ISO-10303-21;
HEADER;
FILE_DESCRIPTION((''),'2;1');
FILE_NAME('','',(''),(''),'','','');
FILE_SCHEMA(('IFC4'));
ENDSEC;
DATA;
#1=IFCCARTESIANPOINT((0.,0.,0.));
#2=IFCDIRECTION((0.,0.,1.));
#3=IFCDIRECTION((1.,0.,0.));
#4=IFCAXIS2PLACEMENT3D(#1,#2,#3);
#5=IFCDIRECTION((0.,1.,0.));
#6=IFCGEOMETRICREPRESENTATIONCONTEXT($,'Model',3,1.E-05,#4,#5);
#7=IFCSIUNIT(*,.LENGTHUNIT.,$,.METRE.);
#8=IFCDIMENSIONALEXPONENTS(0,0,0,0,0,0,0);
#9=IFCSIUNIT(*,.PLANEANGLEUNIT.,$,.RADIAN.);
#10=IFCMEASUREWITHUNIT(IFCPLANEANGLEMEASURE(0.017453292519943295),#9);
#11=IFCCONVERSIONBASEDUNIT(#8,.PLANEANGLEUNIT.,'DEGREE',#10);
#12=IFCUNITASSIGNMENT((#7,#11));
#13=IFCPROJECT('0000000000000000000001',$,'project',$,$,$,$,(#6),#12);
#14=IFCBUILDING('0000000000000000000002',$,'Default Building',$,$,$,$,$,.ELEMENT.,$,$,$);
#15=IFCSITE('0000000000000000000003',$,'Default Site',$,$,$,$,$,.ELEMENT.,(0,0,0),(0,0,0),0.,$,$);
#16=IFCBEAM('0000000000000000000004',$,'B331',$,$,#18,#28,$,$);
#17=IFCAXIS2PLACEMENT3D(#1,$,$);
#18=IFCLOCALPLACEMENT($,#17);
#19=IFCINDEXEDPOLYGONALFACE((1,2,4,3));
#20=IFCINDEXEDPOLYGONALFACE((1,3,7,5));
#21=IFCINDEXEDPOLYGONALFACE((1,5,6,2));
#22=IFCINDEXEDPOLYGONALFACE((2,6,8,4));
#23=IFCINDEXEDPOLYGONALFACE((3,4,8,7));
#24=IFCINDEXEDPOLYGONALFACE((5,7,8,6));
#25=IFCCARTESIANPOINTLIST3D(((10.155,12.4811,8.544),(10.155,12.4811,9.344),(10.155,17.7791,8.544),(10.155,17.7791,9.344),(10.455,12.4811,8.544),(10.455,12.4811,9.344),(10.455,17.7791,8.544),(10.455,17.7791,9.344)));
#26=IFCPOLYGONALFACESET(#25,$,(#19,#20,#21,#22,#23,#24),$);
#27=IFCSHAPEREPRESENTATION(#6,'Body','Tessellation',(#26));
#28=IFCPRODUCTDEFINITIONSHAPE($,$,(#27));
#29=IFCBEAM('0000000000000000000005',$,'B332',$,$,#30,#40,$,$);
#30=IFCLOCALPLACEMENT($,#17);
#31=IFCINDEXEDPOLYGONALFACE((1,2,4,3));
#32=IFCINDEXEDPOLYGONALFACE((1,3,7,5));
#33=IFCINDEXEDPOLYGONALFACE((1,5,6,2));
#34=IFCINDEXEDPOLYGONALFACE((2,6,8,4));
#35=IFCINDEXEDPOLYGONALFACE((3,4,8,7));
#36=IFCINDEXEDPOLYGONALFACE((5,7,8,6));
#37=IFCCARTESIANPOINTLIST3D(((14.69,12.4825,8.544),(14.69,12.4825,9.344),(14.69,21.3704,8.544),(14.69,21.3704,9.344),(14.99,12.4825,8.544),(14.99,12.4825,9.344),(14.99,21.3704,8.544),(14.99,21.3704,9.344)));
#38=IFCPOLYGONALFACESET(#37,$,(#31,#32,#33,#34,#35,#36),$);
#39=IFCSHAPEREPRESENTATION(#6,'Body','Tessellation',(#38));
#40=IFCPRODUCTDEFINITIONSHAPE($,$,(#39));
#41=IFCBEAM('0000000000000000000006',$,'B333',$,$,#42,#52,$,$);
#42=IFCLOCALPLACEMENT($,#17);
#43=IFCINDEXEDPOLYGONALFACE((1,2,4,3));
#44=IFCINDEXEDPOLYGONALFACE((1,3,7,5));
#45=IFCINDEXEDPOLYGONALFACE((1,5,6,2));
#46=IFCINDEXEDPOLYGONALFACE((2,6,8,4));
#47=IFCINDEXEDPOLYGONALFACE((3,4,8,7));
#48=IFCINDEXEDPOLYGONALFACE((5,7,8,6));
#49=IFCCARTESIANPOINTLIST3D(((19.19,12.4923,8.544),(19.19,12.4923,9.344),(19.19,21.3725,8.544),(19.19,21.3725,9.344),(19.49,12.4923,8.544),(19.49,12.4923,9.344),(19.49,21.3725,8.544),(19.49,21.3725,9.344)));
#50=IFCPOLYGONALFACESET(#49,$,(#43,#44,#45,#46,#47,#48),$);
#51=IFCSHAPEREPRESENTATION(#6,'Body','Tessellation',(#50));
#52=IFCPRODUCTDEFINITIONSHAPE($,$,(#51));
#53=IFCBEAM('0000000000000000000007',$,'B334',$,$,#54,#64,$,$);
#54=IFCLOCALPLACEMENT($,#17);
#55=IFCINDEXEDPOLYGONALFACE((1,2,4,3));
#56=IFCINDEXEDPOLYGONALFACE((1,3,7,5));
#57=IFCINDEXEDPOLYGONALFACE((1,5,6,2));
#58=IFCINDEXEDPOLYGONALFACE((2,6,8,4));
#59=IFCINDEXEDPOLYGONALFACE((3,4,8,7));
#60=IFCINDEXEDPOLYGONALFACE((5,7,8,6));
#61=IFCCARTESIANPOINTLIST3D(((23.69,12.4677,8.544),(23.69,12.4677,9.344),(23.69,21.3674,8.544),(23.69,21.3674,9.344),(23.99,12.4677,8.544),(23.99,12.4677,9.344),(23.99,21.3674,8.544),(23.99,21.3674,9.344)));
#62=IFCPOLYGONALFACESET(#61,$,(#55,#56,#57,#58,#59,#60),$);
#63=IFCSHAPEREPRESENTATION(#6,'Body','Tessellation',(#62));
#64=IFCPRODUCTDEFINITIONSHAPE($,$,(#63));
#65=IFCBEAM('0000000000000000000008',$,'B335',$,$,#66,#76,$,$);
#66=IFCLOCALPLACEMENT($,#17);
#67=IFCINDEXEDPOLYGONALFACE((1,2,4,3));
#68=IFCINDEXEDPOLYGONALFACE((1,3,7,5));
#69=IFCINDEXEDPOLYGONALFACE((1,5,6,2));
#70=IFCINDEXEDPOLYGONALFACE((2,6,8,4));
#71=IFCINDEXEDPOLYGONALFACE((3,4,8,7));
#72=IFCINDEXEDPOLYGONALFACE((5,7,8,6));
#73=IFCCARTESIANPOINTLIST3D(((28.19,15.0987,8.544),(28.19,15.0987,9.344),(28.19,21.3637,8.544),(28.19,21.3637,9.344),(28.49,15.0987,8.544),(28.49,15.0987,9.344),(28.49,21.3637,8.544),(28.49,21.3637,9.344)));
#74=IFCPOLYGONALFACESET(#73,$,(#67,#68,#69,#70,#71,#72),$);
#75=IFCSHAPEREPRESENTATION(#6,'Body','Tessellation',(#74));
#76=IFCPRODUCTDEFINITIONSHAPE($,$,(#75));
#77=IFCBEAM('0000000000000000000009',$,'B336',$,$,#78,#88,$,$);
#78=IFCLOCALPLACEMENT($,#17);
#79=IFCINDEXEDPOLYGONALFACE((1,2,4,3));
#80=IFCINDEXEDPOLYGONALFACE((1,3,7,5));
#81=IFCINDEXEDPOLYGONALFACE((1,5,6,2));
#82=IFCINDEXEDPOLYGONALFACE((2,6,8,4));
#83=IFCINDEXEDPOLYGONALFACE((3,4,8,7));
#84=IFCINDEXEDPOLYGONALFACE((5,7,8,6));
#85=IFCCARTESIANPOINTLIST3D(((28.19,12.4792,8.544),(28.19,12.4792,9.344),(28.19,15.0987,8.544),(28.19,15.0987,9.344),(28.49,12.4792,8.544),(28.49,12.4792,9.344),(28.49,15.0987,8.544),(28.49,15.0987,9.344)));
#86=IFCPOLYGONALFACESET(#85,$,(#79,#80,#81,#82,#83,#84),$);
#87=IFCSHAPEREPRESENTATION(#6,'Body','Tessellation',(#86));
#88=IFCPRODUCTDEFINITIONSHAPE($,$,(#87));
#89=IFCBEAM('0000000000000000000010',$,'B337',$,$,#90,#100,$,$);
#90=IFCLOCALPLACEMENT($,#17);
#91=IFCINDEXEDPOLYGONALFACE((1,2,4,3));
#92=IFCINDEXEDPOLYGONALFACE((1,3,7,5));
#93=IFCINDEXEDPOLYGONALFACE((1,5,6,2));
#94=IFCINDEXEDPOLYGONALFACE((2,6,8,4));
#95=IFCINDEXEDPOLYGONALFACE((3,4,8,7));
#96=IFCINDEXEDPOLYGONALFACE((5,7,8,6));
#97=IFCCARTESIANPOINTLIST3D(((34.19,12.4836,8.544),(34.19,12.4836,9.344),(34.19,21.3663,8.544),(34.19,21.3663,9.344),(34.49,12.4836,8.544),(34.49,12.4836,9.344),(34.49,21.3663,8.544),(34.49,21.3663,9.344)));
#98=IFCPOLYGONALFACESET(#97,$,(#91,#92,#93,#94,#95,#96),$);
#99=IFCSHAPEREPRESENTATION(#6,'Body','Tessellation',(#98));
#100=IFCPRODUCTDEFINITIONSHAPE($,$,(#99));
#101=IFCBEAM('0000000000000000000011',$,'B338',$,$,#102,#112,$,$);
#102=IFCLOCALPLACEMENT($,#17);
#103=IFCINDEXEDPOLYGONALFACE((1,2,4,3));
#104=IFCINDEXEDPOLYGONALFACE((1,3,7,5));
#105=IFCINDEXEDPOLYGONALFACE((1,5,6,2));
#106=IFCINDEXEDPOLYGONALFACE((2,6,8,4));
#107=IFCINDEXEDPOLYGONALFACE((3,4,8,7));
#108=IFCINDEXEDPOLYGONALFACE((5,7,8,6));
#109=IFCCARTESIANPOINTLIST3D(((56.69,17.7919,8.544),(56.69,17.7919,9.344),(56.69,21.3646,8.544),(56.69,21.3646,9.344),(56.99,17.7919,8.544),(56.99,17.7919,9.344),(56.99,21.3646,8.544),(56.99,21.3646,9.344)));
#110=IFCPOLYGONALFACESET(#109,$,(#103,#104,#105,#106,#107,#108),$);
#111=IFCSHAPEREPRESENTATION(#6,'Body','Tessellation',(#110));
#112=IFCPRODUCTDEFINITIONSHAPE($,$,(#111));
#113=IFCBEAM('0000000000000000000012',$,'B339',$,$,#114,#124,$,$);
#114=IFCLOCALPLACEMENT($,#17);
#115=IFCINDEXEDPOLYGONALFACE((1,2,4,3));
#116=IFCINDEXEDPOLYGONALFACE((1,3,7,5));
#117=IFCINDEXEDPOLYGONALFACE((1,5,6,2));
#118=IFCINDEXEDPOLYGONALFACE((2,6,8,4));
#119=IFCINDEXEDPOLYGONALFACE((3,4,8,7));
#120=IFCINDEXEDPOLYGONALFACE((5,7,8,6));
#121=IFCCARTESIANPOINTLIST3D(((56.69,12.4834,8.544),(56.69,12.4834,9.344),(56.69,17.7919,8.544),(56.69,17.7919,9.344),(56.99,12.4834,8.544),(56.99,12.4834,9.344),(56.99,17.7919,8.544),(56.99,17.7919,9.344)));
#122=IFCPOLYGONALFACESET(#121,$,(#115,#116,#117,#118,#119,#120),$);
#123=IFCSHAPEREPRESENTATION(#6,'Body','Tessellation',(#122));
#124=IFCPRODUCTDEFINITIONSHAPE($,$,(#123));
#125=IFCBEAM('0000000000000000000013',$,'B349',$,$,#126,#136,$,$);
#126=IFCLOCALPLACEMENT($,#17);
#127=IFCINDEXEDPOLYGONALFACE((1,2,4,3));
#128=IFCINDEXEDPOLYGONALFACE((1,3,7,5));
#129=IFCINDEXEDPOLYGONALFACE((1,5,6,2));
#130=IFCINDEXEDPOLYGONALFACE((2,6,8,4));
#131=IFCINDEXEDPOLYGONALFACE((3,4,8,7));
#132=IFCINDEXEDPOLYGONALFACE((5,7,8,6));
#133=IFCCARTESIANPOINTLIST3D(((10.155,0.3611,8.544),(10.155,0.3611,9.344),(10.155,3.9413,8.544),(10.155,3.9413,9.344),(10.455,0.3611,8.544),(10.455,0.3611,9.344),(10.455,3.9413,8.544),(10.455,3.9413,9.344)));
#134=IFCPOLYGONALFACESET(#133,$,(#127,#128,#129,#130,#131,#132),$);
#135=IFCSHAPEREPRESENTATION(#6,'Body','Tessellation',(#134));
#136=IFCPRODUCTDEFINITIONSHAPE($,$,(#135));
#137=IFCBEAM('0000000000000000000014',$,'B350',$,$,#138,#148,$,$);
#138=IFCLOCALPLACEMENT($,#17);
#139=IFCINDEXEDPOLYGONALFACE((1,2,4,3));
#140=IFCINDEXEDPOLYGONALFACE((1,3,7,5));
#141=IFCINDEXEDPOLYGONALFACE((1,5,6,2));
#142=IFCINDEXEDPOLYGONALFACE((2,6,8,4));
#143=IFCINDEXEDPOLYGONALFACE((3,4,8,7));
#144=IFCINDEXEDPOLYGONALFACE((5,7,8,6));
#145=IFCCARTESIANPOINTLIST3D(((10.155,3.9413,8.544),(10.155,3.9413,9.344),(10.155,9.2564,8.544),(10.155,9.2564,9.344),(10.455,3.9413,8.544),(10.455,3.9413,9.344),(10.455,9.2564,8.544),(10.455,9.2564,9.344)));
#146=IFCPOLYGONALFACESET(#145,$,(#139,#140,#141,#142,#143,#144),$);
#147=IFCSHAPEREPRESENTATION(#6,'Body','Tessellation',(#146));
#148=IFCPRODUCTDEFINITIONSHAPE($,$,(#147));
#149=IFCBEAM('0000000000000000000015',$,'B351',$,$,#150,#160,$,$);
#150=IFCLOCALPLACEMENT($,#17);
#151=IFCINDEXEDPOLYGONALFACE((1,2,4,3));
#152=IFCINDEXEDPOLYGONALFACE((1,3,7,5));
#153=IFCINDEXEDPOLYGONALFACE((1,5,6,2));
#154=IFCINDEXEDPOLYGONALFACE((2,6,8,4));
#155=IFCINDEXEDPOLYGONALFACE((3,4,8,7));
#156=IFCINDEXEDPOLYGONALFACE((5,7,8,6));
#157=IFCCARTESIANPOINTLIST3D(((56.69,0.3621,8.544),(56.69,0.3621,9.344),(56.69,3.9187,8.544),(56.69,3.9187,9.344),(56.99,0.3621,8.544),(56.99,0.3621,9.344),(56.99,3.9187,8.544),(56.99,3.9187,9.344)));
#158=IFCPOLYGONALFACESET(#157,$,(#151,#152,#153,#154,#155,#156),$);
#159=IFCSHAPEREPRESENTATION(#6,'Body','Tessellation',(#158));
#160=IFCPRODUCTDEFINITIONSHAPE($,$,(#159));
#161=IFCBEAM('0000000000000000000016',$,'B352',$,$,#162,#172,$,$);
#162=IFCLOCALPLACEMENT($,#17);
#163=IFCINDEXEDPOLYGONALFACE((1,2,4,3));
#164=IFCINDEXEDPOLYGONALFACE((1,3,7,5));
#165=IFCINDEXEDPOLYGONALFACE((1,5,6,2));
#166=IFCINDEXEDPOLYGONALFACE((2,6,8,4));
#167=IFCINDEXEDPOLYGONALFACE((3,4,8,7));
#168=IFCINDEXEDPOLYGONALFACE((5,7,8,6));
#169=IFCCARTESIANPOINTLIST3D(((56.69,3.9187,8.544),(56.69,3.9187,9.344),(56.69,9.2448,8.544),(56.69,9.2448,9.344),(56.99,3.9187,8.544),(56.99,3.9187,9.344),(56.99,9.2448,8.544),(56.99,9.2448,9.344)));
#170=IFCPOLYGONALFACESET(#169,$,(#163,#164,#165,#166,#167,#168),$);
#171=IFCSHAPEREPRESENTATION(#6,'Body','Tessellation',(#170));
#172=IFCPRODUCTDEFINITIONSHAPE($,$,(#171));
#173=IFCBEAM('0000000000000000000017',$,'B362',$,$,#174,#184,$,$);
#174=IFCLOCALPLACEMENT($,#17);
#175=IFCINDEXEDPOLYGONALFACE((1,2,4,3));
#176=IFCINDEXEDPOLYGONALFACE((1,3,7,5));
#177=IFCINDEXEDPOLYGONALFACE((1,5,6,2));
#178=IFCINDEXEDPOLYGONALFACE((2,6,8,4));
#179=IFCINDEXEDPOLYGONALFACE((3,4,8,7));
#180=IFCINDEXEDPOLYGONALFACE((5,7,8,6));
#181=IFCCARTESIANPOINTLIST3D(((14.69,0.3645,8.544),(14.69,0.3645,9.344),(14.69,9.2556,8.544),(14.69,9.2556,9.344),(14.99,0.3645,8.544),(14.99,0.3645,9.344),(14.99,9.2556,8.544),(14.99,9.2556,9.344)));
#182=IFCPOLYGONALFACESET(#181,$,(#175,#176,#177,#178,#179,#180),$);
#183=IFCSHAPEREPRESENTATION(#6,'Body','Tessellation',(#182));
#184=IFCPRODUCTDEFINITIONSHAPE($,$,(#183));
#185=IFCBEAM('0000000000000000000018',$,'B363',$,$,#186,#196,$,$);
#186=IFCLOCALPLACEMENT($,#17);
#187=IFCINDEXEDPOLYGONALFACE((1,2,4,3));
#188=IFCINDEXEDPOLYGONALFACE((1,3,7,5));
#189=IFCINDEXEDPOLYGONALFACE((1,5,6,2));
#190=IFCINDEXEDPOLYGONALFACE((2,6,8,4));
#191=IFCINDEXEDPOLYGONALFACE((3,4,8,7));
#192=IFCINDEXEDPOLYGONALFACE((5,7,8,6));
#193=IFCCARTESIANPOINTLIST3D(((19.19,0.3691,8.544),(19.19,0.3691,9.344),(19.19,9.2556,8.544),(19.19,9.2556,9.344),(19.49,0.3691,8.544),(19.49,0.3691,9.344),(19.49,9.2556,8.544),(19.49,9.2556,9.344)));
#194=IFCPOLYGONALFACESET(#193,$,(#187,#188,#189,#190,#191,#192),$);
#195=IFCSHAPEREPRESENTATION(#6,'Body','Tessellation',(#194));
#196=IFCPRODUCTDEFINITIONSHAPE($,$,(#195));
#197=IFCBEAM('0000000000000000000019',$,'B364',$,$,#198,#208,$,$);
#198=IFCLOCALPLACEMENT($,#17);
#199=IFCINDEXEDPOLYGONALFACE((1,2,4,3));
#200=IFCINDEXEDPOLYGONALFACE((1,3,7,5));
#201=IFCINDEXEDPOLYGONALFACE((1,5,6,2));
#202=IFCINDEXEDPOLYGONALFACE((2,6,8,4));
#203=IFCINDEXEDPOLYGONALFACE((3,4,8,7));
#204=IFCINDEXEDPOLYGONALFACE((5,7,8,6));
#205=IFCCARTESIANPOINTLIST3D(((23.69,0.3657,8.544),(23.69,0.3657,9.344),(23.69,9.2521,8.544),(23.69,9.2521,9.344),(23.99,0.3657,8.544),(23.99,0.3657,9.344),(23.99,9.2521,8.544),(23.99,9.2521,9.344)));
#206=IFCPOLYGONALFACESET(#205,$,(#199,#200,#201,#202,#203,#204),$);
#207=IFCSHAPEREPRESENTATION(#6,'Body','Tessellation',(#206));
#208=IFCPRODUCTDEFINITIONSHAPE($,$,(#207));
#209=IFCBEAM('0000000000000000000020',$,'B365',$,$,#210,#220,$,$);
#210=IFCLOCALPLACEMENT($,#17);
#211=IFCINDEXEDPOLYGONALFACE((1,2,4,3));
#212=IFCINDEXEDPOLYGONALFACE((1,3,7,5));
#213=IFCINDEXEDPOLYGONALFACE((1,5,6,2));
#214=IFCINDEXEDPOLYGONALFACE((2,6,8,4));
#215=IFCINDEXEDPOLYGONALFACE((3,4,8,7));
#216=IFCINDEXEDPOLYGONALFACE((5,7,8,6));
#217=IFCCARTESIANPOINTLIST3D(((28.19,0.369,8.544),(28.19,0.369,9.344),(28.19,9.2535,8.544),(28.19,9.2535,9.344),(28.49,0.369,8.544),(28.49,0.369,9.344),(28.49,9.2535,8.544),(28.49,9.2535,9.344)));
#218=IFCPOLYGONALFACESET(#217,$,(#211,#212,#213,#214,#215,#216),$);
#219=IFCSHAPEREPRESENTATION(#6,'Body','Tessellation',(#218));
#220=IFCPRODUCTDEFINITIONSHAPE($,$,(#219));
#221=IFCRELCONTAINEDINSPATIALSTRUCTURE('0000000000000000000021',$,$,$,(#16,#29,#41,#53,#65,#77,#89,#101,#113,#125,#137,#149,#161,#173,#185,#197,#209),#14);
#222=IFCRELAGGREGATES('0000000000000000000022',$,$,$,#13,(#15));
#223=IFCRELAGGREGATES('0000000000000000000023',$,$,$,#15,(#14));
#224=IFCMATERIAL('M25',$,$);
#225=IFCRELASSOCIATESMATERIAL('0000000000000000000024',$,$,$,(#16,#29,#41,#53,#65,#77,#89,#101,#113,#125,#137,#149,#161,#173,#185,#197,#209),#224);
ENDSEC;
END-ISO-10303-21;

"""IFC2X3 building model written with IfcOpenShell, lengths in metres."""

from ifc_helpers import new_model, entity, si_unit, converted_unit, direction, frame, frame_2d, origin_with_axes, place, context, project, spatial, rectangle, extrude, material, element, save


model = new_model("IFC2X3")

# Units and contexts
model_context = context("Model", 3, precision=1e-05, world=origin_with_axes(), true_north=direction((0.0, 1.0, 0.0)))
ifc_project = project(units=[si_unit("LENGTHUNIT", "METRE"), converted_unit("PLANEANGLEUNIT", "DEGREE", entity("IfcPlaneAngleMeasure", 0.017453292519943295), si_unit("PLANEANGLEUNIT", "RADIAN"), dimensions=[0, 0, 0, 0, 0, 0, 0])], contexts=[model_context])

# Site, building
site = spatial("IfcSite", under=ifc_project, Name="Default Site", CompositionType="ELEMENT", RefLatitude=(0, 0, 0), RefLongitude=(0, 0, 0), RefElevation=0.0)
building = spatial("IfcBuilding", under=site, Name="Default Building", CompositionType="ELEMENT")

# Beams
ifc_material = material(Name="M25")
placement = place(None, origin_with_axes())
element("IfcBeam", 1, at=placement, inside=building, material=ifc_material, Name="B331", context=model_context, shape_type="SweptSolid", body=[
    extrude(rectangle(XDim=0.3, YDim=0.8, at=frame_2d((0.0, 0.0), x_axis=(0.0, 1.0, 0.0))), frame((10.305, 17.7791, 8.944), z_axis=(0.0, -1.0, 0.0), x_axis=(0.0, 0.0, -1.0)), (0.0, 0.0, 1.0), 5.298),
])
element("IfcBeam", 2, at=placement, inside=building, material=ifc_material, Name="B332", context=model_context, shape_type="SweptSolid", body=[
    extrude(rectangle(XDim=0.3, YDim=0.8, at=frame_2d((0.0, 0.0), x_axis=(0.0, 1.0, 0.0))), frame((14.84, 21.3704, 8.944), z_axis=(0.0, -1.0, 0.0), x_axis=(0.0, 0.0, -1.0)), (0.0, 0.0, 1.0), 8.8879),
])
element("IfcBeam", 3, at=placement, inside=building, material=ifc_material, Name="B333", context=model_context, shape_type="SweptSolid", body=[
    extrude(rectangle(XDim=0.3, YDim=0.8, at=frame_2d((0.0, 0.0), x_axis=(0.0, 1.0, 0.0))), frame((19.34, 21.3725, 8.944), z_axis=(0.0, -1.0, 0.0), x_axis=(0.0, 0.0, -1.0)), (0.0, 0.0, 1.0), 8.8802),
])
element("IfcBeam", 4, at=placement, inside=building, material=ifc_material, Name="B334", context=model_context, shape_type="SweptSolid", body=[
    extrude(rectangle(XDim=0.3, YDim=0.8, at=frame_2d((0.0, 0.0), x_axis=(0.0, 1.0, 0.0))), frame((23.84, 21.3674, 8.944), z_axis=(0.0, -1.0, 0.0), x_axis=(0.0, 0.0, -1.0)), (0.0, 0.0, 1.0), 8.8997),
])
element("IfcBeam", 5, at=placement, inside=building, material=ifc_material, Name="B335", context=model_context, shape_type="SweptSolid", body=[
    extrude(rectangle(XDim=0.3, YDim=0.8, at=frame_2d((0.0, 0.0), x_axis=(0.0, 1.0, 0.0))), frame((28.34, 21.3637, 8.944), z_axis=(0.0, -1.0, 0.0), x_axis=(0.0, 0.0, -1.0)), (0.0, 0.0, 1.0), 6.265),
])
element("IfcBeam", 6, at=placement, inside=building, material=ifc_material, Name="B336", context=model_context, shape_type="SweptSolid", body=[
    extrude(rectangle(XDim=0.3, YDim=0.8, at=frame_2d((0.0, 0.0), x_axis=(0.0, 1.0, 0.0))), frame((28.34, 15.0987, 8.944), z_axis=(0.0, -1.0, 0.0), x_axis=(0.0, 0.0, -1.0)), (0.0, 0.0, 1.0), 2.6195),
])
element("IfcBeam", 7, at=placement, inside=building, material=ifc_material, Name="B337", context=model_context, shape_type="SweptSolid", body=[
    extrude(rectangle(XDim=0.3, YDim=0.8, at=frame_2d((0.0, 0.0), x_axis=(0.0, 1.0, 0.0))), frame((34.34, 12.4836, 8.944), z_axis=(0.0, 1.0, 0.0), x_axis=(0.0, 0.0, -1.0)), (0.0, 0.0, 1.0), 8.8827),
])
element("IfcBeam", 8, at=placement, inside=building, material=ifc_material, Name="B338", context=model_context, shape_type="SweptSolid", body=[
    extrude(rectangle(XDim=0.3, YDim=0.8, at=frame_2d((0.0, 0.0), x_axis=(0.0, 1.0, 0.0))), frame((56.84, 17.7919, 8.944), z_axis=(0.0, 1.0, 0.0), x_axis=(0.0, 0.0, -1.0)), (0.0, 0.0, 1.0), 3.5727),
])
element("IfcBeam", 9, at=placement, inside=building, material=ifc_material, Name="B339", context=model_context, shape_type="SweptSolid", body=[
    extrude(rectangle(XDim=0.3, YDim=0.8, at=frame_2d((0.0, 0.0), x_axis=(0.0, 1.0, 0.0))), frame((56.84, 12.4834, 8.944), z_axis=(0.0, 1.0, 0.0), x_axis=(0.0, 0.0, -1.0)), (0.0, 0.0, 1.0), 5.3085),
])
element("IfcBeam", 10, at=placement, inside=building, material=ifc_material, Name="B349", context=model_context, shape_type="SweptSolid", body=[
    extrude(rectangle(XDim=0.3, YDim=0.8, at=frame_2d((0.0, 0.0), x_axis=(0.0, 1.0, 0.0))), frame((10.305, 3.9413, 8.944), z_axis=(0.0, -1.0, 0.0), x_axis=(0.0, 0.0, -1.0)), (0.0, 0.0, 1.0), 3.5802),
])
element("IfcBeam", 11, at=placement, inside=building, material=ifc_material, Name="B350", context=model_context, shape_type="SweptSolid", body=[
    extrude(rectangle(XDim=0.3, YDim=0.8, at=frame_2d((0.0, 0.0), x_axis=(0.0, 1.0, 0.0))), frame((10.305, 3.9413, 8.944), z_axis=(0.0, 1.0, 0.0), x_axis=(0.0, 0.0, -1.0)), (0.0, 0.0, 1.0), 5.3151),
])
element("IfcBeam", 12, at=placement, inside=building, material=ifc_material, Name="B351", context=model_context, shape_type="SweptSolid", body=[
    extrude(rectangle(XDim=0.3, YDim=0.8, at=frame_2d((0.0, 0.0), x_axis=(0.0, 1.0, 0.0))), frame((56.84, 0.3621, 8.944), z_axis=(0.0, 1.0, 0.0), x_axis=(0.0, 0.0, -1.0)), (0.0, 0.0, 1.0), 3.5566),
])
element("IfcBeam", 13, at=placement, inside=building, material=ifc_material, Name="B352", context=model_context, shape_type="SweptSolid", body=[
    extrude(rectangle(XDim=0.3, YDim=0.8, at=frame_2d((0.0, 0.0), x_axis=(0.0, 1.0, 0.0))), frame((56.84, 3.9187, 8.944), z_axis=(0.0, 1.0, 0.0), x_axis=(0.0, 0.0, -1.0)), (0.0, 0.0, 1.0), 5.3261),
])
element("IfcBeam", 14, at=placement, inside=building, material=ifc_material, Name="B362", context=model_context, shape_type="SweptSolid", body=[
    extrude(rectangle(XDim=0.3, YDim=0.8, at=frame_2d((0.0, 0.0), x_axis=(0.0, 1.0, 0.0))), frame((14.84, 0.3645, 8.944), z_axis=(0.0, 1.0, 0.0), x_axis=(0.0, 0.0, -1.0)), (0.0, 0.0, 1.0), 8.891),
])
element("IfcBeam", 15, at=placement, inside=building, material=ifc_material, Name="B363", context=model_context, shape_type="SweptSolid", body=[
    extrude(rectangle(XDim=0.3, YDim=0.8, at=frame_2d((0.0, 0.0), x_axis=(0.0, 1.0, 0.0))), frame((19.34, 0.3691, 8.944), z_axis=(0.0, 1.0, 0.0), x_axis=(0.0, 0.0, -1.0)), (0.0, 0.0, 1.0), 8.8865),
])
element("IfcBeam", 16, at=placement, inside=building, material=ifc_material, Name="B364", context=model_context, shape_type="SweptSolid", body=[
    extrude(rectangle(XDim=0.3, YDim=0.8, at=frame_2d((0.0, 0.0), x_axis=(0.0, 1.0, 0.0))), frame((23.84, 0.3657, 8.944), z_axis=(0.0, 1.0, 0.0), x_axis=(0.0, 0.0, -1.0)), (0.0, 0.0, 1.0), 8.8864),
])
element("IfcBeam", 17, at=placement, inside=building, material=ifc_material, Name="B365", context=model_context, shape_type="SweptSolid", body=[
    extrude(rectangle(XDim=0.3, YDim=0.8, at=frame_2d((0.0, 0.0), x_axis=(0.0, 1.0, 0.0))), frame((28.34, 0.369, 8.944), z_axis=(0.0, 1.0, 0.0), x_axis=(0.0, 0.0, -1.0)), (0.0, 0.0, 1.0), 8.8845),
])

save(model, "model.ifc")
